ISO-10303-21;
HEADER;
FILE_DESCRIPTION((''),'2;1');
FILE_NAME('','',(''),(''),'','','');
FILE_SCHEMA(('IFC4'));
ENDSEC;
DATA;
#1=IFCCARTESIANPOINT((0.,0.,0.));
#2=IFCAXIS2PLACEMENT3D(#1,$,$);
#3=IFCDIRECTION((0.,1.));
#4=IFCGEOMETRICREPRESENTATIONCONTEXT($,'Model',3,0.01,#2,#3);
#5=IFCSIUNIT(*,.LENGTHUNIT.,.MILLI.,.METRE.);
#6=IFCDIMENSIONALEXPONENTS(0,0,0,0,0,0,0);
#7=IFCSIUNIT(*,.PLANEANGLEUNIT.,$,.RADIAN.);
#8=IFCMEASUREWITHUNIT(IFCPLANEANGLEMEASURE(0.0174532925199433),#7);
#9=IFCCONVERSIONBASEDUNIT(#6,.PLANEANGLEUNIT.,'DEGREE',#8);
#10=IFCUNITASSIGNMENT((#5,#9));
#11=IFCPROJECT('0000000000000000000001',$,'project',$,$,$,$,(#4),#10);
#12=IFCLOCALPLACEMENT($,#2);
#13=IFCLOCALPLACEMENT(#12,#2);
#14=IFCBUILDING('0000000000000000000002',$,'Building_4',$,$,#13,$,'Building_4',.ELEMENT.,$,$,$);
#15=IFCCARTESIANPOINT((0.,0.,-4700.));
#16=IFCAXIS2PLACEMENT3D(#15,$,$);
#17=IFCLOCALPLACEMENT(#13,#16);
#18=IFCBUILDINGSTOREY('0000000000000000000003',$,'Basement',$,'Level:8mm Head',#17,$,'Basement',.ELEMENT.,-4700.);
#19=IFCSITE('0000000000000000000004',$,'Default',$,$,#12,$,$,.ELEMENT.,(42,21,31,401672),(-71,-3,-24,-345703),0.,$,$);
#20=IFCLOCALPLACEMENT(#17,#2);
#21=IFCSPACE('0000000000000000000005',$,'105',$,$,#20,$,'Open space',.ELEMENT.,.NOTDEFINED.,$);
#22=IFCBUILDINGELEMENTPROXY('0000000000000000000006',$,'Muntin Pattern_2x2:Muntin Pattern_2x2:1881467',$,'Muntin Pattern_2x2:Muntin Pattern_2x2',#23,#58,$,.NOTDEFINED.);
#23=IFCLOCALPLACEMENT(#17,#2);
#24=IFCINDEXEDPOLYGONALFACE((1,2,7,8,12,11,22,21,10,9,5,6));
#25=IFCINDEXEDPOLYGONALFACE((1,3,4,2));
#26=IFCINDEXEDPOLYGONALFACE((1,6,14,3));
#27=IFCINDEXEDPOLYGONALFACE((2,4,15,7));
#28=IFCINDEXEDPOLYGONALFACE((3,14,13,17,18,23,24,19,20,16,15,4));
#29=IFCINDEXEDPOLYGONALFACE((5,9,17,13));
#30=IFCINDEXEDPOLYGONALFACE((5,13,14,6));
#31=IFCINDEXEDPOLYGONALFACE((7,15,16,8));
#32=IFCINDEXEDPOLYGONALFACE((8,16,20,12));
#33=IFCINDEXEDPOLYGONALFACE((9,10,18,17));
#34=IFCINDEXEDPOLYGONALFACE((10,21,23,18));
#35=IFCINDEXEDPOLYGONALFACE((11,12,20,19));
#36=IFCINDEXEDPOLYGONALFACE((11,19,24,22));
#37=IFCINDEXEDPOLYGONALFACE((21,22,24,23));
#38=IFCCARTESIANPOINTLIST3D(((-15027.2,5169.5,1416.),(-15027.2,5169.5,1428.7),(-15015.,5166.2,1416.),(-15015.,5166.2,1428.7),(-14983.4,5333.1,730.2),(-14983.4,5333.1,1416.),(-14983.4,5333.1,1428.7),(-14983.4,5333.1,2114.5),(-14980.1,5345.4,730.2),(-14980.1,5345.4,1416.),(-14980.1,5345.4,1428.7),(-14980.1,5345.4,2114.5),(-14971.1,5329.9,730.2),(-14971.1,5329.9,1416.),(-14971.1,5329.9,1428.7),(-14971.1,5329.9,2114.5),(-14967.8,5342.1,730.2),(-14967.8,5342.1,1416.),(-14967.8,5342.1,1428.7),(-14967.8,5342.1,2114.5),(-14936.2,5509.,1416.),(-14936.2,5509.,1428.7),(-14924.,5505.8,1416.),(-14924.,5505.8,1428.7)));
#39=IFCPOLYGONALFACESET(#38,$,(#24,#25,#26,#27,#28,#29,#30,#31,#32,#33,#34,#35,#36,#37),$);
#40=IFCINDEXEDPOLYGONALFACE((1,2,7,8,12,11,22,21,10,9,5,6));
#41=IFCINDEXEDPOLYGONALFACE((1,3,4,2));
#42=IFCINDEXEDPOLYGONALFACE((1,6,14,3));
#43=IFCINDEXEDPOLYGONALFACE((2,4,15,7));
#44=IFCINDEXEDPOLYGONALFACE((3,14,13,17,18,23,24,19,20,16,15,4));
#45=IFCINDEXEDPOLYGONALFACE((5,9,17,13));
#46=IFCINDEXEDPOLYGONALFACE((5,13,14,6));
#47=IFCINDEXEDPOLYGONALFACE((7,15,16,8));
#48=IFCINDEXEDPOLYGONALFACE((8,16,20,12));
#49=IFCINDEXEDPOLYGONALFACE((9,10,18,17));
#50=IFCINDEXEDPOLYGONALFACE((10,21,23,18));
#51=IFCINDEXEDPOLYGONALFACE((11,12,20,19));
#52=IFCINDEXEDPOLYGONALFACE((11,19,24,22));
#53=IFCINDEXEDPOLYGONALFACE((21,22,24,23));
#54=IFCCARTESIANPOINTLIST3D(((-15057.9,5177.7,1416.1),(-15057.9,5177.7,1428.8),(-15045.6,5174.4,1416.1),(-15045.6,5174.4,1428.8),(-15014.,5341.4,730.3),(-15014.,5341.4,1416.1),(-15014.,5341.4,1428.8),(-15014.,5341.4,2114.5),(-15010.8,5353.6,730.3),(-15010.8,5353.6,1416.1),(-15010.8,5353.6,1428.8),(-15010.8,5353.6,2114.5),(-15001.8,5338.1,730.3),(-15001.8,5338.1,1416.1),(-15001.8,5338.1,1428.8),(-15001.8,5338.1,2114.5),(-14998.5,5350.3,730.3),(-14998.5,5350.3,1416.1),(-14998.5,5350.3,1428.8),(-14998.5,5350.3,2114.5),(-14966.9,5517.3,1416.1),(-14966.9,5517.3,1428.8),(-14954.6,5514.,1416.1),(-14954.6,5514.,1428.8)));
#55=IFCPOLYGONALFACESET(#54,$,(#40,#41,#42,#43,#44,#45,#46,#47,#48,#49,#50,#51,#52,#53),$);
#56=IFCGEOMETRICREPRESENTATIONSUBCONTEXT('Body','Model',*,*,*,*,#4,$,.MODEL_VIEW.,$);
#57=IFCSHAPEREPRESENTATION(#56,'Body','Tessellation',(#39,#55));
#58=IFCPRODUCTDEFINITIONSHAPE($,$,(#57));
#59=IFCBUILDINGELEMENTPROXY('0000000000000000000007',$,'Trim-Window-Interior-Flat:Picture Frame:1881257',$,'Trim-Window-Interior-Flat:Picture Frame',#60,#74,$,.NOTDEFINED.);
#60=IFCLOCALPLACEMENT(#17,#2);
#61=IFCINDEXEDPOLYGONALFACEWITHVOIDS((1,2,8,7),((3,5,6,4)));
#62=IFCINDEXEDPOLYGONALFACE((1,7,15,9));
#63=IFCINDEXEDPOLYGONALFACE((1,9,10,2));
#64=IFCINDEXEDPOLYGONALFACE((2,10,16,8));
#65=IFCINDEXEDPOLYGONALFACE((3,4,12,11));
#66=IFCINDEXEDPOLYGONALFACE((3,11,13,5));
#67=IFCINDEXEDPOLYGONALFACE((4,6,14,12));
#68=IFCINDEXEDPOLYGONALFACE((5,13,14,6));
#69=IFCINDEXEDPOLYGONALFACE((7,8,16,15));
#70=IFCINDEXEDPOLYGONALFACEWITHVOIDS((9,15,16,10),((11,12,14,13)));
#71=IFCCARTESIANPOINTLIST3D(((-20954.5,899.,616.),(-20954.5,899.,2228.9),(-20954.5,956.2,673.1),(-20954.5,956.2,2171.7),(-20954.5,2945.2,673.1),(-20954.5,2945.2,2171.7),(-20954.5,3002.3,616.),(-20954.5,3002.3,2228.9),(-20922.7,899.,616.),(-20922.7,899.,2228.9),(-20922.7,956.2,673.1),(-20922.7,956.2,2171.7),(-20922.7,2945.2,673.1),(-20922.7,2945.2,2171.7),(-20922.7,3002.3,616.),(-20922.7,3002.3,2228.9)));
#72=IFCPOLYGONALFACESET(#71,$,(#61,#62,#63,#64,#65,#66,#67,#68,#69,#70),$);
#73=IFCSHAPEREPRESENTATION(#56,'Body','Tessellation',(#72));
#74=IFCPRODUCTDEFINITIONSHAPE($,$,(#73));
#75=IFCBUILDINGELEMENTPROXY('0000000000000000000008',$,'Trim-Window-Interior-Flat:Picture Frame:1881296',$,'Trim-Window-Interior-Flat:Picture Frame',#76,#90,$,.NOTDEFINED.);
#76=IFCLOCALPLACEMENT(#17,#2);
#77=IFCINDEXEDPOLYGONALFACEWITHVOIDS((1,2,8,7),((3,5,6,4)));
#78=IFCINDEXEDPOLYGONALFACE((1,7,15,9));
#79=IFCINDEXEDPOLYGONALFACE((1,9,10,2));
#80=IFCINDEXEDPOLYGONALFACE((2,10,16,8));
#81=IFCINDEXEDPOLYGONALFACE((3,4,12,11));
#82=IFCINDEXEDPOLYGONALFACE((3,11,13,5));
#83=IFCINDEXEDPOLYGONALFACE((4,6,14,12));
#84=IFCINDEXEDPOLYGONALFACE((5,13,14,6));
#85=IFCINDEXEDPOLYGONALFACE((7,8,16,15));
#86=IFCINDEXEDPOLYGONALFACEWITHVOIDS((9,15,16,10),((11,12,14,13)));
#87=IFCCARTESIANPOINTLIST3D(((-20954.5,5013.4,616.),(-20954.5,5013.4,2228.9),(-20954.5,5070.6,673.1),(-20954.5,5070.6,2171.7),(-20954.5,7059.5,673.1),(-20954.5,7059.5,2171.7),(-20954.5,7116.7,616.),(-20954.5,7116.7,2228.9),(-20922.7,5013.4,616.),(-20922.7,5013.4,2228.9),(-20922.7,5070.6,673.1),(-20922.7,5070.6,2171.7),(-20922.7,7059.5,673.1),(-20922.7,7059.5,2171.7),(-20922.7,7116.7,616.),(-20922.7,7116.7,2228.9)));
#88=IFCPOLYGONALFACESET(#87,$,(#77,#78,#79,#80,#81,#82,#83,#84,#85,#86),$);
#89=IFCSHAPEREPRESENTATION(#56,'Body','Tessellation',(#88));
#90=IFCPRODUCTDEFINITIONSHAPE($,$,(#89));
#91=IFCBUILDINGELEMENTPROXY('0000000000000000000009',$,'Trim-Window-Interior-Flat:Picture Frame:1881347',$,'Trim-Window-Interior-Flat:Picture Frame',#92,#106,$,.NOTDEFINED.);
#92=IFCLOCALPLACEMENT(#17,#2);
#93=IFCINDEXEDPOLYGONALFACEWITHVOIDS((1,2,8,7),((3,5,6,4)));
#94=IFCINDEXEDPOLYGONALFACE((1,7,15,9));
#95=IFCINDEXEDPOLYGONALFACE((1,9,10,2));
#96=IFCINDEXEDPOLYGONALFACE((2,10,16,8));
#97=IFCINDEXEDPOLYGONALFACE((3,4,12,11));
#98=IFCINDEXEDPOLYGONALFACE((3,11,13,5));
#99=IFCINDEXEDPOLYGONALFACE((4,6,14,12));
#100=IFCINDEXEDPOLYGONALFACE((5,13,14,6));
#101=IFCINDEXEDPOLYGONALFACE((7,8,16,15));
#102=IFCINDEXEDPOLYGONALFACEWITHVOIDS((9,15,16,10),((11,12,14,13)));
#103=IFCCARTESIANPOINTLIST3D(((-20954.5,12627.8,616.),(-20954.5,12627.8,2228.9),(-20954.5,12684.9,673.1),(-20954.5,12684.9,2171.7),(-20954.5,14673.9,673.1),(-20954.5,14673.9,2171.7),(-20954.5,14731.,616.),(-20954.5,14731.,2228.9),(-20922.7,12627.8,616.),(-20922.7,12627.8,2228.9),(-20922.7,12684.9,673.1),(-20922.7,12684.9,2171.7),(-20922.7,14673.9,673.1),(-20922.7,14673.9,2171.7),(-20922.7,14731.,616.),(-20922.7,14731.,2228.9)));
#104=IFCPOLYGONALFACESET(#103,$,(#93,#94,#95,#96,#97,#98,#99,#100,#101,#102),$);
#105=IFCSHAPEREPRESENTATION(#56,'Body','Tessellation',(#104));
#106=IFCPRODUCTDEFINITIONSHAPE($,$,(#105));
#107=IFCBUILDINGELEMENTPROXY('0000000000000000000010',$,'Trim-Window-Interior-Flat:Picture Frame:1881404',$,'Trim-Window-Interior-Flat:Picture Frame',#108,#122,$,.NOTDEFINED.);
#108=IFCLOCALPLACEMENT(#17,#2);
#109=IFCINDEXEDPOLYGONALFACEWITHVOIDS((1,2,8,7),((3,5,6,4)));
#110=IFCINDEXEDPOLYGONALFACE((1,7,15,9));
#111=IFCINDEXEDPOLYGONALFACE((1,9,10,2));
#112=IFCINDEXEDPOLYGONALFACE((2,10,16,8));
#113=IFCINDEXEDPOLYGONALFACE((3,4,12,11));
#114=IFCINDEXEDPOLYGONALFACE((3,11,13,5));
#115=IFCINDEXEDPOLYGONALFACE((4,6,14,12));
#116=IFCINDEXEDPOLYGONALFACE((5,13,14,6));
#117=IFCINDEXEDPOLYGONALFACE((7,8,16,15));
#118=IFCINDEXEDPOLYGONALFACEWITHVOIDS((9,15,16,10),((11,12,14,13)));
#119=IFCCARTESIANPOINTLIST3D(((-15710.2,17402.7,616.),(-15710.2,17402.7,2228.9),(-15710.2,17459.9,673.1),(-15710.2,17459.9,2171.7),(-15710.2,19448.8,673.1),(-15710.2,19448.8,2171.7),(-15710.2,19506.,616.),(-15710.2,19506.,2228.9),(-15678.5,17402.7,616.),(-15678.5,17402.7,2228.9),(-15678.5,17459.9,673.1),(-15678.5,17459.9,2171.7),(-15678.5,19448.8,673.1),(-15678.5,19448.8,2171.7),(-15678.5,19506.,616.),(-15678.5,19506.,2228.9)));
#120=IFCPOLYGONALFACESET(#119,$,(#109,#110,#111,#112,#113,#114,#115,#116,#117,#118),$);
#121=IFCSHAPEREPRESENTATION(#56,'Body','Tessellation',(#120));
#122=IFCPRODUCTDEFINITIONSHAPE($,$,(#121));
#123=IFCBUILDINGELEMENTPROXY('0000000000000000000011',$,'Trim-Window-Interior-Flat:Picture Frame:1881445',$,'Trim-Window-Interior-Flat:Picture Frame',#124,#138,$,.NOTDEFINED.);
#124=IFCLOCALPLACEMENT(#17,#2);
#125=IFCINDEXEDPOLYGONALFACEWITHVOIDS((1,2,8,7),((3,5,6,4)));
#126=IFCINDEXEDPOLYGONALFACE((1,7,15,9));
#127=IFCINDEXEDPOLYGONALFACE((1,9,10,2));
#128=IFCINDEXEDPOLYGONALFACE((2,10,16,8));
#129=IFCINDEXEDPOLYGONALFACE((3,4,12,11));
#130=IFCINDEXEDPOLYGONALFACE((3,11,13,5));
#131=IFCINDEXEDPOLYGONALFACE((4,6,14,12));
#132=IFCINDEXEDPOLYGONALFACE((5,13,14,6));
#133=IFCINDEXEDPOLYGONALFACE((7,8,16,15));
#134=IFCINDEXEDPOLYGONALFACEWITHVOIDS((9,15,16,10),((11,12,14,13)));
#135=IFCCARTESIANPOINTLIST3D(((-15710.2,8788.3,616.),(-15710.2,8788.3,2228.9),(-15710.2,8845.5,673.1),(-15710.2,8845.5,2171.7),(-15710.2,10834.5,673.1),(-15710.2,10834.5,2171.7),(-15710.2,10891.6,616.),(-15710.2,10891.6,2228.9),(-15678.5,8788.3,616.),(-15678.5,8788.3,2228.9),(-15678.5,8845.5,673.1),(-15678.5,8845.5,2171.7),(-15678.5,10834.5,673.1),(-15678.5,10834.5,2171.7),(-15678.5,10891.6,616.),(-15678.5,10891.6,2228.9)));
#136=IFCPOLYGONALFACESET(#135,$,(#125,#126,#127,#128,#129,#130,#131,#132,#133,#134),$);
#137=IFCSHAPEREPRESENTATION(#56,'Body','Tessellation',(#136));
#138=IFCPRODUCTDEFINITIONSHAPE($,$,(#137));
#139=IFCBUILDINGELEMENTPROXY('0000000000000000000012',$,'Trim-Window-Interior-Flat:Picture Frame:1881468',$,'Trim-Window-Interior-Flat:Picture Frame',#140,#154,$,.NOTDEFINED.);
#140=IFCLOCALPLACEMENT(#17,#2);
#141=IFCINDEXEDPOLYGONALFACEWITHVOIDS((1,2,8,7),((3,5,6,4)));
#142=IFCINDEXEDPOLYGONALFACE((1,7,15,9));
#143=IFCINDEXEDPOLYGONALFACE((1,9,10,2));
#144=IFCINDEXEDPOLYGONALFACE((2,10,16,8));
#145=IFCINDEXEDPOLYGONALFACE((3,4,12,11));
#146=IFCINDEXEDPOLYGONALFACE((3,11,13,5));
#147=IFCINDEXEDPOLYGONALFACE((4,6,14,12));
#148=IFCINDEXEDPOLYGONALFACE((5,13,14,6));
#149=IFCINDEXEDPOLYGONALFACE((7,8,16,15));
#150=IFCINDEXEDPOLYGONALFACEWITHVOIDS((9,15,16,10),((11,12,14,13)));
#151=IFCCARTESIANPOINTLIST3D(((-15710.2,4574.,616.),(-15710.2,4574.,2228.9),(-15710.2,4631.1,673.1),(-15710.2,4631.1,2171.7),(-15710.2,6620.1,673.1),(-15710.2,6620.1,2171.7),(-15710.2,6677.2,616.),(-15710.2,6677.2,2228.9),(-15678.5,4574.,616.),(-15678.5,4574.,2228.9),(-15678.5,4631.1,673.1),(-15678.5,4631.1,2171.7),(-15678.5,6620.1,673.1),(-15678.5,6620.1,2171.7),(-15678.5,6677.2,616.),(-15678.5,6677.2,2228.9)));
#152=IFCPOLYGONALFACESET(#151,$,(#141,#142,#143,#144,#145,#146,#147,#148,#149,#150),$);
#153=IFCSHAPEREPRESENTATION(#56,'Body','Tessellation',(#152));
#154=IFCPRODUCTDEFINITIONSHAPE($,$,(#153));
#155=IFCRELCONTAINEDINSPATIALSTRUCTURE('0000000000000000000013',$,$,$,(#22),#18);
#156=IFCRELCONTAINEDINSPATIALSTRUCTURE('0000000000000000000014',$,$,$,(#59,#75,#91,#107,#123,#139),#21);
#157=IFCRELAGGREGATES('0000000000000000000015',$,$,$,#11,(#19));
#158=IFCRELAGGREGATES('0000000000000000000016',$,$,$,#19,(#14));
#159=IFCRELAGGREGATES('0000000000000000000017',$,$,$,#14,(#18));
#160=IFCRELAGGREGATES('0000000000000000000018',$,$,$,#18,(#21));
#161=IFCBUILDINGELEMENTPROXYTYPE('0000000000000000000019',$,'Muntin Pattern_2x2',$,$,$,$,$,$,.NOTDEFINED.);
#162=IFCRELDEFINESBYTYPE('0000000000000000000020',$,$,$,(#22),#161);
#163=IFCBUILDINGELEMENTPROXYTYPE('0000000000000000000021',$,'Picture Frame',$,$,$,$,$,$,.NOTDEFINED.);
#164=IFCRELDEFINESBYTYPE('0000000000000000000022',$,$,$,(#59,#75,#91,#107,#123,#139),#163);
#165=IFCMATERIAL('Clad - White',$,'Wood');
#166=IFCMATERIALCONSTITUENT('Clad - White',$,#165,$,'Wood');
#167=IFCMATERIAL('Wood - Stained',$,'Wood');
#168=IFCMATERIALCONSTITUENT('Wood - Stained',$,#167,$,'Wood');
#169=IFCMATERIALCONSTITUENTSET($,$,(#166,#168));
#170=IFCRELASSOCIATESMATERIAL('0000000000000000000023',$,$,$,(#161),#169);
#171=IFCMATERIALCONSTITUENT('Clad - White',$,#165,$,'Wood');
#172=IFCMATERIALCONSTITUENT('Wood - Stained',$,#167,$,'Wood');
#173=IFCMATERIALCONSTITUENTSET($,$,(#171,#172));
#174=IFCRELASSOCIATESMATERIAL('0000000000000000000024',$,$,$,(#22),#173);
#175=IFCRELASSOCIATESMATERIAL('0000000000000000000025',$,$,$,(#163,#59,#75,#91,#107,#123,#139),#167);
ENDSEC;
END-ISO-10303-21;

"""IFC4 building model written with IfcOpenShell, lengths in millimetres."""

from ifc_helpers import new_model, entity, si_unit, converted_unit, direction, frame, origin, place, context, subcontext, project, spatial, indexed_curve, outline, extrude, source, transform, mapped, material, constituent, constituent_set, type_object, type_shapes, element, save


model = new_model("IFC4")

# Units and contexts
model_context = context("Model", 3, precision=0.01, world=origin(), true_north=direction((0.0, 1.0)))
body_context = subcontext(model_context, "Body", "Model", "MODEL_VIEW")
ifc_project = project(units=[si_unit("LENGTHUNIT", "METRE", prefix="MILLI"), converted_unit("PLANEANGLEUNIT", "DEGREE", entity("IfcPlaneAngleMeasure", 0.0174532925199433), si_unit("PLANEANGLEUNIT", "RADIAN"), dimensions=[0, 0, 0, 0, 0, 0, 0])], contexts=[model_context])

# Site, building, storey
site_placement = place(None, origin())
site = spatial("IfcSite", under=ifc_project, at=site_placement, Name="Default", CompositionType="ELEMENT", RefLatitude=(42, 21, 31, 401672), RefLongitude=(-71, -3, -24, -345703), RefElevation=0.0)
building_placement = place(site_placement, origin())
building = spatial("IfcBuilding", under=site, at=building_placement, Name="Building_4", LongName="Building_4", CompositionType="ELEMENT")
storey_placement = place(building_placement, frame((0.0, 0.0, -4700.0)))
storey = spatial("IfcBuildingStorey", under=building, at=storey_placement, Name="Basement", ObjectType="Level:8mm Head", LongName="Basement", CompositionType="ELEMENT", Elevation=-4700.0)

# Building element proxy
ifc_material_1 = material(Name="Clad - White", Category="Wood")
ifc_material_2 = material(Name="Wood - Stained", Category="Wood")
ifc_constituent_1 = constituent(ifc_material_1, Name="Clad - White", Category="Wood")
ifc_constituent_2 = constituent(ifc_material_2, Name="Wood - Stained", Category="Wood")
ifc_constituent_set_1 = constituent_set(constituents=[ifc_constituent_1, ifc_constituent_2])
building_element_proxy_type_1 = type_object("IfcBuildingElementProxyType", Name="Muntin Pattern_2x2", PredefinedType="NOTDEFINED", material=ifc_constituent_set_1)
shared_shape_1 = source(origin(), body_context, "Body", "SweptSolid", [
    extrude(outline(indexed_curve([(6.4, -6.4), (692.1, -6.4), (692.1, 6.3), (6.4, 6.3), (6.4, 175.8), (-6.3, 175.8), (-6.3, 6.3), (-692.2, 6.3), (-692.2, -6.4), (-6.3, -6.4), (-6.3, -175.8), (6.4, -175.8), (6.4, -6.4)], self_intersect=False)), frame((0.0, -22.2, 692.1), z_axis=(0.0, 1.0, 0.0), x_axis=(0.0, 0.0, 1.0)), (0.0, 0.0, 1.0), 12.7),
    extrude(outline(indexed_curve([(6.4, -6.4), (692.1, -6.4), (692.1, 6.3), (6.4, 6.3), (6.4, 175.8), (-6.3, 175.8), (-6.3, 6.3), (-692.1, 6.3), (-692.1, -6.4), (-6.3, -6.4), (-6.3, -175.8), (6.4, -175.8), (6.4, -6.4)], self_intersect=False)), frame((0.0, 9.5, 692.1), z_axis=(0.0, 1.0, 0.0), x_axis=(0.0, 0.0, 1.0)), (0.0, 0.0, 1.0), 12.7),
])
type_shapes(building_element_proxy_type_1, [shared_shape_1])
ifc_constituent_3 = constituent(ifc_material_1, Name="Clad - White", Category="Wood")
ifc_constituent_4 = constituent(ifc_material_2, Name="Wood - Stained", Category="Wood")
ifc_constituent_set_2 = constituent_set(constituents=[ifc_constituent_3, ifc_constituent_4])
proxy_1_placement = place(storey_placement, frame((-14990.9, 5341.7, 730.3), z_axis=(0.0, 0.0, 1.0), x_axis=(0.258819, 0.965926, 0.0)))
element("IfcBuildingElementProxy", 1, at=proxy_1_placement, inside=storey, type_object=building_element_proxy_type_1, material=ifc_constituent_set_2, Name="Muntin Pattern_2x2:Muntin Pattern_2x2:1881467", ObjectType="Muntin Pattern_2x2:Muntin Pattern_2x2", PredefinedType="NOTDEFINED", context=body_context, shape_type="MappedRepresentation", body=[
    mapped(shared_shape_1, transform((0.0, 0.0, 0.0), scale=1.0)),
])

# Shared definitions
space_placement = place(storey_placement, origin())
space = spatial("IfcSpace", under=storey, at=space_placement, Name="105", LongName="Open space", CompositionType="ELEMENT", PredefinedType="NOTDEFINED")

# Building element proxies
building_element_proxy_type_2 = type_object("IfcBuildingElementProxyType", Name="Picture Frame", PredefinedType="NOTDEFINED", material=ifc_material_2)
shared_shape_2 = source(origin(), body_context, "Body", "SweptSolid", [
    extrude(outline(indexed_curve([(-1051.6, -806.4), (1051.6, -806.4), (1051.6, 806.4), (-1051.6, 806.4), (-1051.6, -806.4)], self_intersect=False), holes=[indexed_curve([(-994.5, -749.3), (-994.5, 749.3), (994.5, 749.3), (994.5, -749.3), (-994.5, -749.3)], self_intersect=False)]), frame((0.0, -762.0, 0.0), z_axis=(0.0, 0.0, 1.0), x_axis=(-1.0, 0.0, 0.0)), (0.0, 0.0, 1.0), 31.8),
])
type_shapes(building_element_proxy_type_2, [shared_shape_2])
for number, where, z_axis, x_axis, name in (
    (2, (-20954.5, 1950.7, 2184.4), (1.0, 0.0, 0.0), (0.0, 1.0, 0.0), "Trim-Window-Interior-Flat:Picture Frame:1881257"),
    (3, (-20954.5, 6065.0, 2184.4), (1.0, 0.0, 0.0), (0.0, 1.0, 0.0), "Trim-Window-Interior-Flat:Picture Frame:1881296"),
    (4, (-20954.5, 13679.4, 2184.4), (1.0, 0.0, 0.0), (0.0, 1.0, 0.0), "Trim-Window-Interior-Flat:Picture Frame:1881347"),
    (5, (-15678.5, 18454.3, 2184.4), (-1.0, 0.0, 0.0), (0.0, -1.0, 0.0), "Trim-Window-Interior-Flat:Picture Frame:1881404"),
    (6, (-15678.5, 9840.0, 2184.4), (-1.0, 0.0, 0.0), (0.0, -1.0, 0.0), "Trim-Window-Interior-Flat:Picture Frame:1881445"),
    (7, (-15678.5, 5625.6, 2184.4), (-1.0, 0.0, 0.0), (0.0, -1.0, 0.0), "Trim-Window-Interior-Flat:Picture Frame:1881468"),
):
    element("IfcBuildingElementProxy", number, at=place(space_placement, frame(where, z_axis=z_axis, x_axis=x_axis)), inside=space, type_object=building_element_proxy_type_2, material=ifc_material_2, Name=name, ObjectType="Trim-Window-Interior-Flat:Picture Frame", PredefinedType="NOTDEFINED", context=body_context, shape_type="MappedRepresentation", body=[
        mapped(shared_shape_2, transform((0.0, 0.0, 0.0), scale=1.0)),
    ])

save(model, "model.ifc")
